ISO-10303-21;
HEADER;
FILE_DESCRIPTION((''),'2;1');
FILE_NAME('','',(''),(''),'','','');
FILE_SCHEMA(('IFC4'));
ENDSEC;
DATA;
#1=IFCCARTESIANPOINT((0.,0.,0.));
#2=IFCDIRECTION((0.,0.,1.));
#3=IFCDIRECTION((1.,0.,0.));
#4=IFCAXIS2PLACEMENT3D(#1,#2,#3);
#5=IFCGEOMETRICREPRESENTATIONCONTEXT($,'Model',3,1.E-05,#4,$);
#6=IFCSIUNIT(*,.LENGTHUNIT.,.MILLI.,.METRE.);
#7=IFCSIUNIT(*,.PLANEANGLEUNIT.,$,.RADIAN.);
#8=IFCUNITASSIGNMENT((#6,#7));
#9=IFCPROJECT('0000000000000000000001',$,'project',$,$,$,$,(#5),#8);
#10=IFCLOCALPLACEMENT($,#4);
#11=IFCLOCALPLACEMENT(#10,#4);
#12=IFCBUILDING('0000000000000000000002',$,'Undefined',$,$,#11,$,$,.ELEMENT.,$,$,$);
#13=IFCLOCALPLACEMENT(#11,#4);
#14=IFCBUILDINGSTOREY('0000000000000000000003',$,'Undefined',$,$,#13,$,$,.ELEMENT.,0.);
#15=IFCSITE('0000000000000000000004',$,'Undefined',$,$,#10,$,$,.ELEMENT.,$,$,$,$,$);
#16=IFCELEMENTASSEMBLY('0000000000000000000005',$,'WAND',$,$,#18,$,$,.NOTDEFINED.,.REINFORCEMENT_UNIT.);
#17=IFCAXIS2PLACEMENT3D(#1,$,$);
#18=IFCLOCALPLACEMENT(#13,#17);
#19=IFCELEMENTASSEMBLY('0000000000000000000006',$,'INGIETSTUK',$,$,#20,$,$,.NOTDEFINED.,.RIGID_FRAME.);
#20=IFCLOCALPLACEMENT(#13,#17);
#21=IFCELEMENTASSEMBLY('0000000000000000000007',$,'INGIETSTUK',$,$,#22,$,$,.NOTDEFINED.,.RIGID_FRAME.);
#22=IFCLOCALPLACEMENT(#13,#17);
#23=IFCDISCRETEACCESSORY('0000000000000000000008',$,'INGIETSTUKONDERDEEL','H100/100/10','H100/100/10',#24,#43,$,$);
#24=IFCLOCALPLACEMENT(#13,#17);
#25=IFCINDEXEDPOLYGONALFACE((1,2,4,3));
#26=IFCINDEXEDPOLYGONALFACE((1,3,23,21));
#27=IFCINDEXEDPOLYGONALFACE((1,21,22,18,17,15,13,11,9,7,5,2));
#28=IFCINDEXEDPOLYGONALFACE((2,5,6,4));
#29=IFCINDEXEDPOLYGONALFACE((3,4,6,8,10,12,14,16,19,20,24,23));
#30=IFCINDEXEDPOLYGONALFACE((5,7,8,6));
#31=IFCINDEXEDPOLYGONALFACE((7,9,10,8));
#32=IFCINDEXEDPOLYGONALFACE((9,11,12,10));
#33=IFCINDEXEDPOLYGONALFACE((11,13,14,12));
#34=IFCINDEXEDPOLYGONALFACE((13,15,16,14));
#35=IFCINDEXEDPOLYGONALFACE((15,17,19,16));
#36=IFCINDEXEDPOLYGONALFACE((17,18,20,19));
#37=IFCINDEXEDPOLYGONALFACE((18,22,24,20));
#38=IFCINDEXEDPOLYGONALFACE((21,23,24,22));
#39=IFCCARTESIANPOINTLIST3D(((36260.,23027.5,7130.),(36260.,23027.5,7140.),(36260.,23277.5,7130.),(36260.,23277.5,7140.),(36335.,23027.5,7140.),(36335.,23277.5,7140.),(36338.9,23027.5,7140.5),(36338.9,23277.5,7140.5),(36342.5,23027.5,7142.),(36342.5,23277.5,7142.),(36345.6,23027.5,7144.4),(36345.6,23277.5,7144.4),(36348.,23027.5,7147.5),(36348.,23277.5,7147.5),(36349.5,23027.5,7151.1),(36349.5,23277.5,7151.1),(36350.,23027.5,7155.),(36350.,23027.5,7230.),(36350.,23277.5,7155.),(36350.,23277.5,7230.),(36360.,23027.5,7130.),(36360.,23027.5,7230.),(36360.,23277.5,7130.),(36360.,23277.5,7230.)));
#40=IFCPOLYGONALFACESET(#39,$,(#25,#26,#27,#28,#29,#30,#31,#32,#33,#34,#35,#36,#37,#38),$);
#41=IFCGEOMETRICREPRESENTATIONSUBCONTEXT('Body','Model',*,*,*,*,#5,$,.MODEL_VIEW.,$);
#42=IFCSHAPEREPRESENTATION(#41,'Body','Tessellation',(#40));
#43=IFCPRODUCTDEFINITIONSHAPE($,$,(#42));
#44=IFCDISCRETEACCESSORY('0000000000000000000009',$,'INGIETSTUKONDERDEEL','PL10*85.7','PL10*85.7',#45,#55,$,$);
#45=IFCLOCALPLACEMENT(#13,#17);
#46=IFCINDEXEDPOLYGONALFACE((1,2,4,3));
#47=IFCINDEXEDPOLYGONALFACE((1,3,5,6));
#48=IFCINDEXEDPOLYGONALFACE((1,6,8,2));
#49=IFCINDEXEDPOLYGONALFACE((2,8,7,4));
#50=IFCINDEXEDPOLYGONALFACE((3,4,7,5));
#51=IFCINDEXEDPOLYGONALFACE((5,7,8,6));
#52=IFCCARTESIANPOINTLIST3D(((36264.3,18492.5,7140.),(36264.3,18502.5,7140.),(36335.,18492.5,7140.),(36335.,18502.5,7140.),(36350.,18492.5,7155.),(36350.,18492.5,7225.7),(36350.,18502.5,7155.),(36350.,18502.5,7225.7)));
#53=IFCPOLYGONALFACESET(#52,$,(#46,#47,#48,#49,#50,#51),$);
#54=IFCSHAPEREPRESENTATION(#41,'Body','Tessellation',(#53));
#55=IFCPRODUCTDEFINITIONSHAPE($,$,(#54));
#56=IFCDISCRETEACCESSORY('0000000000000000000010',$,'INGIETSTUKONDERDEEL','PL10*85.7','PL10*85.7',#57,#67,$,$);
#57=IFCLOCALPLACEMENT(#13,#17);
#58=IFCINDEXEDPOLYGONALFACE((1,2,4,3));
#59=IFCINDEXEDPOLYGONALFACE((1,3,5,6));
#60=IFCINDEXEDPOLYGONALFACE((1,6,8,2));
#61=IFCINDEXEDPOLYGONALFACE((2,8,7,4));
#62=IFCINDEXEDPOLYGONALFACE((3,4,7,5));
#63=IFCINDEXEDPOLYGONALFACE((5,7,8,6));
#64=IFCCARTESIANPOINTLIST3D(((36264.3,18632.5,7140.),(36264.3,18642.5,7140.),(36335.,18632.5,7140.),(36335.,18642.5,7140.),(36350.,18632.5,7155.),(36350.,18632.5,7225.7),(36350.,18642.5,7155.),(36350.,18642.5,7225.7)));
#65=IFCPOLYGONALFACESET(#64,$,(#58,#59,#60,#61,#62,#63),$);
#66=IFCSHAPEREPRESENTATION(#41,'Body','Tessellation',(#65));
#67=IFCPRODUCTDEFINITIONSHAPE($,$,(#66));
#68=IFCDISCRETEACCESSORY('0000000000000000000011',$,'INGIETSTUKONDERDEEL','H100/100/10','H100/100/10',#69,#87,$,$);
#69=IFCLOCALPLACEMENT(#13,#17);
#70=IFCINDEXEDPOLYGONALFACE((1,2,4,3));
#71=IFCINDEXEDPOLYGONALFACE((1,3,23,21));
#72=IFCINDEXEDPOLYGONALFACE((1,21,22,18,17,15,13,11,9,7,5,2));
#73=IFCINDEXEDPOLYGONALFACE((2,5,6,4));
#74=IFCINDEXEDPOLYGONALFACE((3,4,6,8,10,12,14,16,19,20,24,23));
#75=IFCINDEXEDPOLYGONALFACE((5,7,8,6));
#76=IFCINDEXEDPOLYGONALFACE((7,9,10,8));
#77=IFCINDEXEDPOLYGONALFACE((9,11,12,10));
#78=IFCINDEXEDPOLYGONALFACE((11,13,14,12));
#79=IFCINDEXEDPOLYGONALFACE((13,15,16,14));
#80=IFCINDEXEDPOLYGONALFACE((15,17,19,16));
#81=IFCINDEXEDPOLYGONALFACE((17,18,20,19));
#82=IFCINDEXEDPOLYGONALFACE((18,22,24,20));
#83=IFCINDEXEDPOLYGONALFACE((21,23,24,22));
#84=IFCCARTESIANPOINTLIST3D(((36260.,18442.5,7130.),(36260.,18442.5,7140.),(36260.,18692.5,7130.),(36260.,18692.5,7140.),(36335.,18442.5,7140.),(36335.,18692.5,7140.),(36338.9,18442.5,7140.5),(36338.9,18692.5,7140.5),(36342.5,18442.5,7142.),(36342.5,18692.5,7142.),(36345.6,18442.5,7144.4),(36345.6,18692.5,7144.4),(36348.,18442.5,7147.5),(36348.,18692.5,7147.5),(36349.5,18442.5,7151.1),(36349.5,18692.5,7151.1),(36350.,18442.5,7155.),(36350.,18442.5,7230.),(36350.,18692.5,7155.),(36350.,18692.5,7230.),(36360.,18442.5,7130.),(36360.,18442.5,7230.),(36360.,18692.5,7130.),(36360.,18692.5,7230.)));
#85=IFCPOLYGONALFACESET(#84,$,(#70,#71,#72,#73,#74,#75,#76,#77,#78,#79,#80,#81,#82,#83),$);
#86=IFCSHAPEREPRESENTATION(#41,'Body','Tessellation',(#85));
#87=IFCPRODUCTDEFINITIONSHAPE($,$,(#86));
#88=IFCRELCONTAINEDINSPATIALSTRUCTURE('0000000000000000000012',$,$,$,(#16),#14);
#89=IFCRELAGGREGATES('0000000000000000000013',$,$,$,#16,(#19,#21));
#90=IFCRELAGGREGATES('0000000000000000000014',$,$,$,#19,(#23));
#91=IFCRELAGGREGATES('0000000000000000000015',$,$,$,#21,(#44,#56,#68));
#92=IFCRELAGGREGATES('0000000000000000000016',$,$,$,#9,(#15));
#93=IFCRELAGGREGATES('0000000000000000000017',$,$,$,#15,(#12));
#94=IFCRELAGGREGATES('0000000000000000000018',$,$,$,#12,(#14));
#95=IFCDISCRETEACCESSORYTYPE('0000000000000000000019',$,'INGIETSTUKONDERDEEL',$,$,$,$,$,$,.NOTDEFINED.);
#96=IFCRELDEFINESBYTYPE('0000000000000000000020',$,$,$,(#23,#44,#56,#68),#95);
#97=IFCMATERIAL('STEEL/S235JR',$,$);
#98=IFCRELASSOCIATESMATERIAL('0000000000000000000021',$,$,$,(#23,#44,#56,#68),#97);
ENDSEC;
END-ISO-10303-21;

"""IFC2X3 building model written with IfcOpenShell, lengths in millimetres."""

from ifc_helpers import new_model, si_unit, frame, frame_2d, origin_with_axes, place, context, subcontext, project, spatial, polyline, l_section, outline, extrude, material, type_object, element, aggregate, save


model = new_model("IFC2X3")

# Units and contexts
model_context = context("Model", 3, precision=1e-05, world=origin_with_axes())
body_context = subcontext(model_context, "Body", "Model", "MODEL_VIEW")
ifc_project = project(units=[si_unit("LENGTHUNIT", "METRE", prefix="MILLI"), si_unit("PLANEANGLEUNIT", "RADIAN")], contexts=[model_context])

# Site, building, storey
site_placement = place(None, origin_with_axes())
site = spatial("IfcSite", under=ifc_project, at=site_placement, Name="Undefined", CompositionType="ELEMENT")
building_placement = place(site_placement, origin_with_axes())
building = spatial("IfcBuilding", under=site, at=building_placement, Name="Undefined", CompositionType="ELEMENT")
storey_placement = place(building_placement, origin_with_axes())
storey = spatial("IfcBuildingStorey", under=building, at=storey_placement, Name="Undefined", CompositionType="ELEMENT", Elevation=0.0)

# Element assemblies
assembly_1_placement = place(storey_placement, origin_with_axes())
assembly_1 = element("IfcElementAssembly", 1, at=assembly_1_placement, inside=storey, Name="WAND", AssemblyPlace="NOTDEFINED", PredefinedType="REINFORCEMENT_UNIT")
assembly_2_placement = place(assembly_1_placement, origin_with_axes())
assembly_2 = element("IfcElementAssembly", 2, at=assembly_2_placement, Name="INGIETSTUK", AssemblyPlace="NOTDEFINED", PredefinedType="RIGID_FRAME")
ifc_material_1 = material(Name="STEEL/S235JR")
assembly_3_placement = place(assembly_1_placement, origin_with_axes())
assembly_3 = element("IfcElementAssembly", 3, at=assembly_3_placement, Name="INGIETSTUK", AssemblyPlace="NOTDEFINED", PredefinedType="RIGID_FRAME")

aggregate(assembly_1, [assembly_2, assembly_3])

# Discrete accessories
discrete_accessory_type = type_object("IfcDiscreteAccessoryType", Name="INGIETSTUKONDERDEEL")
discrete_accessory_1_placement = place(assembly_2_placement, frame((36310.0, 23277.5, 7180.0), z_axis=(0.0, 0.0, 1.0), x_axis=(0.0, -1.0, 0.0)))
discrete_accessory_1 = element("IfcDiscreteAccessory", 4, at=discrete_accessory_1_placement, type_object=discrete_accessory_type, material=ifc_material_1, Name="INGIETSTUKONDERDEEL", Description="H100/100/10", ObjectType="H100/100/10", context=body_context, shape_type="SweptSolid", body=[
    extrude(l_section(Depth=100.0, Width=100.0, Thickness=10.0, FilletRadius=15.0, at=frame_2d((0.0, 0.0), x_axis=(1.0, 0.0))), frame((250.0, 0.0, 0.0), z_axis=(-1.0, 0.0, 0.0), x_axis=(0.0, -1.0, 0.0)), (0.0, 0.0, 1.0), 250.0),
])
aggregate(assembly_2, [discrete_accessory_1])
discrete_accessory_2_placement = place(assembly_3_placement, frame((36350.0, 18497.5, 7225.7), z_axis=(0.0, 1.0, 0.0), x_axis=(0.0, 0.0, -1.0)))
discrete_accessory_2 = element("IfcDiscreteAccessory", 5, at=discrete_accessory_2_placement, type_object=discrete_accessory_type, material=ifc_material_1, Name="INGIETSTUKONDERDEEL", Description="PL10*85.7", ObjectType="PL10*85.7", context=body_context, shape_type="SweptSolid", body=[
    extrude(outline(polyline([(0.0, 0.0), (70.7, 0.0), (85.7, 15.0), (85.7, 85.7), (0.0, 0.0)])), frame((0.0, 0.0, -5.0), z_axis=(0.0, 0.0, 1.0), x_axis=(1.0, 0.0, 0.0)), (0.0, 0.0, 1.0), 10.0),
])
discrete_accessory_3_placement = place(assembly_3_placement, frame((36350.0, 18637.5, 7225.7), z_axis=(0.0, 1.0, 0.0), x_axis=(0.0, 0.0, -1.0)))
discrete_accessory_3 = element("IfcDiscreteAccessory", 6, at=discrete_accessory_3_placement, type_object=discrete_accessory_type, material=ifc_material_1, Name="INGIETSTUKONDERDEEL", Description="PL10*85.7", ObjectType="PL10*85.7", context=body_context, shape_type="SweptSolid", body=[
    extrude(outline(polyline([(0.0, 0.0), (70.7, 0.0), (85.7, 15.0), (85.7, 85.7), (0.0, 0.0)])), frame((0.0, 0.0, -5.0), z_axis=(0.0, 0.0, 1.0), x_axis=(1.0, 0.0, 0.0)), (0.0, 0.0, 1.0), 10.0),
])
discrete_accessory_4_placement = place(assembly_3_placement, frame((36310.0, 18692.5, 7180.0), z_axis=(0.0, 0.0, 1.0), x_axis=(0.0, -1.0, 0.0)))
discrete_accessory_4 = element("IfcDiscreteAccessory", 7, at=discrete_accessory_4_placement, type_object=discrete_accessory_type, material=ifc_material_1, Name="INGIETSTUKONDERDEEL", Description="H100/100/10", ObjectType="H100/100/10", context=body_context, shape_type="SweptSolid", body=[
    extrude(l_section(Depth=100.0, Width=100.0, Thickness=10.0, FilletRadius=15.0, at=frame_2d((0.0, 0.0), x_axis=(1.0, 0.0))), frame((250.0, 0.0, 0.0), z_axis=(-1.0, 0.0, 0.0), x_axis=(0.0, -1.0, 0.0)), (0.0, 0.0, 1.0), 250.0),
])
aggregate(assembly_3, [discrete_accessory_2, discrete_accessory_3, discrete_accessory_4])

save(model, "model.ifc")
